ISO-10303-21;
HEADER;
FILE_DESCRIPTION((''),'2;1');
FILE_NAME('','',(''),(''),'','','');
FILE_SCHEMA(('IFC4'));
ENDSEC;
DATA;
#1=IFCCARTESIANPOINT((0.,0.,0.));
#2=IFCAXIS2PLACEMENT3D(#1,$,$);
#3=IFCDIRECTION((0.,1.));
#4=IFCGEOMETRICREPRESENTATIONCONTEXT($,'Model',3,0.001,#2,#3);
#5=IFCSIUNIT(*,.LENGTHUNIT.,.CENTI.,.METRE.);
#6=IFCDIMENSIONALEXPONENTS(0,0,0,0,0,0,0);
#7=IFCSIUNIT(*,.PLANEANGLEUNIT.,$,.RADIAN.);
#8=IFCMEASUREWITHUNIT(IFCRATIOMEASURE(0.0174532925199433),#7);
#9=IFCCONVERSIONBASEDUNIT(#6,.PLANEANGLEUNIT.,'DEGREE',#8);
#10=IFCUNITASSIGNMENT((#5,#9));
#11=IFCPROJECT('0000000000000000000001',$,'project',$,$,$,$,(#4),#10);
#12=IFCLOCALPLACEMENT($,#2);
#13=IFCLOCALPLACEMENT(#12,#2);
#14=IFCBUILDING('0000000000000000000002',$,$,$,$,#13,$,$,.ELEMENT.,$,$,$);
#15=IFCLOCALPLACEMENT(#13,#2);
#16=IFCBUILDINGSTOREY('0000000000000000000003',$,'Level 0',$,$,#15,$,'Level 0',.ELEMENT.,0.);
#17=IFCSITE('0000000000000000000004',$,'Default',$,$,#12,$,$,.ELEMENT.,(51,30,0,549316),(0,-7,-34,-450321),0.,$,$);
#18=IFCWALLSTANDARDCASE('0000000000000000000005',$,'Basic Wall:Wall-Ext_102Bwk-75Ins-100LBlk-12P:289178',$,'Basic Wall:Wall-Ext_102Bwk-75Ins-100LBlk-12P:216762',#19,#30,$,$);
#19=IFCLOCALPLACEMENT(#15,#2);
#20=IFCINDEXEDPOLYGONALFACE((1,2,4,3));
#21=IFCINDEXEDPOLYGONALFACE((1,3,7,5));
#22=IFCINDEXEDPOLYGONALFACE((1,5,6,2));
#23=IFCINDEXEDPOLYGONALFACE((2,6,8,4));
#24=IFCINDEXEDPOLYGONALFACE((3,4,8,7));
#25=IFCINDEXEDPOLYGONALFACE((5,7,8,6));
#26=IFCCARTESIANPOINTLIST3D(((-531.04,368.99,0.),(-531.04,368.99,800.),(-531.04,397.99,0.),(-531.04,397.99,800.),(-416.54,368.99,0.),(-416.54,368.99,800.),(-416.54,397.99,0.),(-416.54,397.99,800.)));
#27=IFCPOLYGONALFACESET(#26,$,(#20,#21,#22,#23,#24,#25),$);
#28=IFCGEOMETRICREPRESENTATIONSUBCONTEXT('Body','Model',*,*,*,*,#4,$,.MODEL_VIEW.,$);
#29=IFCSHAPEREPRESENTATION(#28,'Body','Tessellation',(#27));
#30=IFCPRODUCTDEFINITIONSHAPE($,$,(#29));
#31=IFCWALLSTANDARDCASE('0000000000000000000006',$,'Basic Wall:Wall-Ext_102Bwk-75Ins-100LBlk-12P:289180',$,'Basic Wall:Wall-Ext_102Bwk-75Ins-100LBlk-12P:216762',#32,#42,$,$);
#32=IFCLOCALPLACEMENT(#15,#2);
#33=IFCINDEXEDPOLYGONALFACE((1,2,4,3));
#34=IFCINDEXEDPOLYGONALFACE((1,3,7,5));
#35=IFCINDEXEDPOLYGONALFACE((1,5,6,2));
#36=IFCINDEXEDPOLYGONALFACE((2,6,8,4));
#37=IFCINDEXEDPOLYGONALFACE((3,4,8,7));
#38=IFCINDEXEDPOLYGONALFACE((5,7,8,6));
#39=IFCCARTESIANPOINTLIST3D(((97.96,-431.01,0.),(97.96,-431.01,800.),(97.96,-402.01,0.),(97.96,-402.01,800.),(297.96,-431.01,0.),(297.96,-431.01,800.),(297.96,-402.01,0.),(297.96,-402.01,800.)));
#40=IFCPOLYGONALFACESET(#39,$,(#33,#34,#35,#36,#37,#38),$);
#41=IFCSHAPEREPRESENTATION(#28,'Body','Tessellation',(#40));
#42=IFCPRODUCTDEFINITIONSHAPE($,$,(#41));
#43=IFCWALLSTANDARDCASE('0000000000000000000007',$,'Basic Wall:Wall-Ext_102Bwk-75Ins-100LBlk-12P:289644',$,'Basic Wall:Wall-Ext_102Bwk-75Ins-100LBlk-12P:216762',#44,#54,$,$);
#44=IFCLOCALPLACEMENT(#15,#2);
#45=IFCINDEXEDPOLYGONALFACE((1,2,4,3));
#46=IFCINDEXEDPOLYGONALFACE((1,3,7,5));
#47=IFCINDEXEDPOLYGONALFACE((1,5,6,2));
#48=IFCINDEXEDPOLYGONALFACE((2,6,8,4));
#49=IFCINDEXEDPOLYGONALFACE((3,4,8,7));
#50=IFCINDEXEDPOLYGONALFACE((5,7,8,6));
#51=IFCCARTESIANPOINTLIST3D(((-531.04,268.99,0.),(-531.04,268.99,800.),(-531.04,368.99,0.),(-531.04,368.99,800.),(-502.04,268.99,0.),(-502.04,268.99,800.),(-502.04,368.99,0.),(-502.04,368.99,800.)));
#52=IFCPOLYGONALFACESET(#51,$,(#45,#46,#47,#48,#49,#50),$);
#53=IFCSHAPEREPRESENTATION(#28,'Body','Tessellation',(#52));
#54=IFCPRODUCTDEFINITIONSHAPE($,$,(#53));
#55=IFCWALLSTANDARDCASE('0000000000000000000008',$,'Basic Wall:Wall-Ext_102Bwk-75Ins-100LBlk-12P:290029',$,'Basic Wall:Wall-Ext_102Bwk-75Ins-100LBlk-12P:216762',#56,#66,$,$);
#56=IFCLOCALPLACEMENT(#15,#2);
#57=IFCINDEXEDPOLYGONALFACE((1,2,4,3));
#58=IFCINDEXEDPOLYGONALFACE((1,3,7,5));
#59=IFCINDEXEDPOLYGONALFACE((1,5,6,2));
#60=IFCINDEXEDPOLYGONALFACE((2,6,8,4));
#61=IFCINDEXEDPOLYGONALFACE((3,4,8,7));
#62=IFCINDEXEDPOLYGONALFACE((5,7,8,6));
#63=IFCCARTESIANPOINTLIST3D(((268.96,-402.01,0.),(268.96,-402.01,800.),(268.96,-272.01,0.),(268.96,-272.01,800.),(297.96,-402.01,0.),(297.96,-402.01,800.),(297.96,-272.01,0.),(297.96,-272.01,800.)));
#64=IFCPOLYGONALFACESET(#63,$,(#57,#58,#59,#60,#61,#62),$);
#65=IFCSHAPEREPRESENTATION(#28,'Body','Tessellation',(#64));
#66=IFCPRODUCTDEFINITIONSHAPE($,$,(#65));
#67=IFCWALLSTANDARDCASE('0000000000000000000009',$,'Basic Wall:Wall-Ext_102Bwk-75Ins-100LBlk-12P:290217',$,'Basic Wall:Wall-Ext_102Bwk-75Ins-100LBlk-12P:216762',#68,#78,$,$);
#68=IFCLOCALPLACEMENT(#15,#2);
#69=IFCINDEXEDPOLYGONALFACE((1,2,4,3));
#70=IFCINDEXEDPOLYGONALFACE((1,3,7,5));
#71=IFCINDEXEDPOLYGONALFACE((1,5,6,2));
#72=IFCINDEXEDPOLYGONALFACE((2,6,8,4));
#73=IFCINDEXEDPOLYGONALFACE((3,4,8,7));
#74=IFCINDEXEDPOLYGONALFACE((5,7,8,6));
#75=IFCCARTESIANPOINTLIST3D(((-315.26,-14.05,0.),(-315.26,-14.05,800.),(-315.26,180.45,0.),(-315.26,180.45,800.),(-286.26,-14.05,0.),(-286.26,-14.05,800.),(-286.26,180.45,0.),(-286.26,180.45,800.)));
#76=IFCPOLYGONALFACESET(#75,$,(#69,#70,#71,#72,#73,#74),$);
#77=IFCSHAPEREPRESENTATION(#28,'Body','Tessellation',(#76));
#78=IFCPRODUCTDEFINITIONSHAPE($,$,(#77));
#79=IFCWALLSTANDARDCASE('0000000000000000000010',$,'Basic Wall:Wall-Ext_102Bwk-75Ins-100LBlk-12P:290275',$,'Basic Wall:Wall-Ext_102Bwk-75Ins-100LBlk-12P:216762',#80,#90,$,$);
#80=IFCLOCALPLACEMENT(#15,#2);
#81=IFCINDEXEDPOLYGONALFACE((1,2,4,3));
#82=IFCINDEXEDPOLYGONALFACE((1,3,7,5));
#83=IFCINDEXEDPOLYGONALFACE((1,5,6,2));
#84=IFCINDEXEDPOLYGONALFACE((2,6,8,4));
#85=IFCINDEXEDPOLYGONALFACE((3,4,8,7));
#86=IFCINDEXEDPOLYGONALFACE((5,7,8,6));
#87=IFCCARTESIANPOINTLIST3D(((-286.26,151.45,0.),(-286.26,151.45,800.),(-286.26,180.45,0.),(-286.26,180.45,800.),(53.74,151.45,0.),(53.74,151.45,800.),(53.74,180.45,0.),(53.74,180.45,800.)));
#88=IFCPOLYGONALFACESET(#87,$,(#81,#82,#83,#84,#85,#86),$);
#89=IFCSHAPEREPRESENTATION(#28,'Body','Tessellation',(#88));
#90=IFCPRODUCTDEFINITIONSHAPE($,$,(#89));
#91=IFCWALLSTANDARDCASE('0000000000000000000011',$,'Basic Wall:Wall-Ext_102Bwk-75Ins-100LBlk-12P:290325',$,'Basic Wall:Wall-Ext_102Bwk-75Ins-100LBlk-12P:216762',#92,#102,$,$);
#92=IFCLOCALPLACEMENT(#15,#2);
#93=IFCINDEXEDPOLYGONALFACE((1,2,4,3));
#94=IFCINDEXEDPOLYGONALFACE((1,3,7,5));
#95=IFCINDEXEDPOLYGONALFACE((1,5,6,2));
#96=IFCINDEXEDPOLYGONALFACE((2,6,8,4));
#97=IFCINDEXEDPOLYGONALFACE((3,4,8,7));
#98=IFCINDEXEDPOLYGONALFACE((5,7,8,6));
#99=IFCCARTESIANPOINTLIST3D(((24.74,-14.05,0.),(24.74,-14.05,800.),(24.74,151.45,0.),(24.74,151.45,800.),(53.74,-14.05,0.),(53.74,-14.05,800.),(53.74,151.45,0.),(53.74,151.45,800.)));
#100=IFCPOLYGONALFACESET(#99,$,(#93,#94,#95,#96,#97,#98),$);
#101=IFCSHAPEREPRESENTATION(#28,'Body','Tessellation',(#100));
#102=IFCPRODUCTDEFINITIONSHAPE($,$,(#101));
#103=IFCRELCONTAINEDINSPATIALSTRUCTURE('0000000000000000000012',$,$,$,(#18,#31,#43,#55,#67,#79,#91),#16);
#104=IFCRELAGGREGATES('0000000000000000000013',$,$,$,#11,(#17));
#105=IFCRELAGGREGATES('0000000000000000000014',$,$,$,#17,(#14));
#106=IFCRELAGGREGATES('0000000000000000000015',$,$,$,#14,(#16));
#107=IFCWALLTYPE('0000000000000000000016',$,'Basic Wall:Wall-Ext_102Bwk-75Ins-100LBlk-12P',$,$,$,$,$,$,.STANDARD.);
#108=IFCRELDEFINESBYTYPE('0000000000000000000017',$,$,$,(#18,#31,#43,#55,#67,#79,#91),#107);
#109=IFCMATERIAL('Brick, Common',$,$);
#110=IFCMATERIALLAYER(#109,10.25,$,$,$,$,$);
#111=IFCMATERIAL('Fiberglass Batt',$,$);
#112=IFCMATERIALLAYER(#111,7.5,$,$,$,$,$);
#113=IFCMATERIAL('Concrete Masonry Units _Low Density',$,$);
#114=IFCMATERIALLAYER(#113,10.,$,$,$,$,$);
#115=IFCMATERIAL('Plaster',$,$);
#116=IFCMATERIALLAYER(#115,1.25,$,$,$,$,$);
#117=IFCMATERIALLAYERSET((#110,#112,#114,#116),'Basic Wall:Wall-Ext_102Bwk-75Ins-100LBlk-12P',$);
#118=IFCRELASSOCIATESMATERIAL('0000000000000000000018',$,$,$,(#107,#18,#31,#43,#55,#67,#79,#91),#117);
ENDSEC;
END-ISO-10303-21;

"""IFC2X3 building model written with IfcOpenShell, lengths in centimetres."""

from ifc_helpers import new_model, entity, si_unit, converted_unit, direction, frame, frame_2d, origin, place, context, subcontext, project, spatial, rectangle, extrude, material, layer, layer_set, layer_usage, type_object, element, save


model = new_model("IFC2X3")

# Units and contexts
model_context = context("Model", 3, precision=0.001, world=origin(), true_north=direction((0.0, 1.0)))
body_context = subcontext(model_context, "Body", "Model", "MODEL_VIEW")
ifc_project = project(units=[si_unit("LENGTHUNIT", "METRE", prefix="CENTI"), converted_unit("PLANEANGLEUNIT", "DEGREE", entity("IfcRatioMeasure", 0.0174532925199433), si_unit("PLANEANGLEUNIT", "RADIAN"), dimensions=[0, 0, 0, 0, 0, 0, 0])], contexts=[model_context])

# Site, building, storey
site_placement = place(None, origin())
site = spatial("IfcSite", under=ifc_project, at=site_placement, Name="Default", CompositionType="ELEMENT", RefLatitude=(51, 30, 0, 549316), RefLongitude=(0, -7, -34, -450321), RefElevation=0.0)
building_placement = place(site_placement, origin())
building = spatial("IfcBuilding", under=site, at=building_placement, CompositionType="ELEMENT")
storey_placement = place(building_placement, origin())
storey = spatial("IfcBuildingStorey", under=building, at=storey_placement, Name="Level 0", LongName="Level 0", CompositionType="ELEMENT", Elevation=0.0)

# Walls
ifc_material_1 = material(Name="Brick, Common")
ifc_layer_1 = layer(ifc_material_1, 10.25)
ifc_material_2 = material(Name="Fiberglass Batt")
ifc_layer_2 = layer(ifc_material_2, 7.5)
ifc_material_3 = material(Name="Concrete Masonry Units _Low Density")
ifc_layer_3 = layer(ifc_material_3, 10.0)
ifc_material_4 = material(Name="Plaster")
ifc_layer_4 = layer(ifc_material_4, 1.25)
ifc_layer_set = layer_set([ifc_layer_1, ifc_layer_2, ifc_layer_3, ifc_layer_4], Name="Basic Wall:Wall-Ext_102Bwk-75Ins-100LBlk-12P")
ifc_layer_usage_1 = layer_usage(ifc_layer_set, "AXIS2", "NEGATIVE", 14.5)
wall_type = type_object("IfcWallType", Name="Basic Wall:Wall-Ext_102Bwk-75Ins-100LBlk-12P", PredefinedType="STANDARD", material=ifc_layer_set)
wall_1_placement = place(storey_placement, frame((-531.04, 383.49, 0.0)))
element("IfcWallStandardCase", 1, at=wall_1_placement, inside=storey, type_object=wall_type, material=ifc_layer_usage_1, Name="Basic Wall:Wall-Ext_102Bwk-75Ins-100LBlk-12P:289178", ObjectType="Basic Wall:Wall-Ext_102Bwk-75Ins-100LBlk-12P:216762", context=body_context, shape_type="SweptSolid", body=[
    extrude(rectangle(XDim=114.5, YDim=29.0, at=frame_2d((57.25, 0.0), x_axis=(-1.0, 0.0))), origin(), (0.0, 0.0, 1.0), 800.0),
])
ifc_layer_usage_2 = layer_usage(ifc_layer_set, "AXIS2", "NEGATIVE", 14.5)
wall_2_placement = place(storey_placement, frame((297.96, -416.51, 0.0), z_axis=(0.0, 0.0, 1.0), x_axis=(-1.0, 0.0, 0.0)))
element("IfcWallStandardCase", 2, at=wall_2_placement, inside=storey, type_object=wall_type, material=ifc_layer_usage_2, Name="Basic Wall:Wall-Ext_102Bwk-75Ins-100LBlk-12P:289180", ObjectType="Basic Wall:Wall-Ext_102Bwk-75Ins-100LBlk-12P:216762", context=body_context, shape_type="SweptSolid", body=[
    extrude(rectangle(XDim=200.0, YDim=29.0, at=frame_2d((100.0, 0.0), x_axis=(-1.0, 0.0))), origin(), (0.0, 0.0, 1.0), 800.0),
])
ifc_layer_usage_3 = layer_usage(ifc_layer_set, "AXIS2", "NEGATIVE", 14.5)
wall_3_placement = place(storey_placement, frame((-516.54, 268.99, 0.0), z_axis=(0.0, 0.0, 1.0), x_axis=(0.0, 1.0, 0.0)))
element("IfcWallStandardCase", 3, at=wall_3_placement, inside=storey, type_object=wall_type, material=ifc_layer_usage_3, Name="Basic Wall:Wall-Ext_102Bwk-75Ins-100LBlk-12P:289644", ObjectType="Basic Wall:Wall-Ext_102Bwk-75Ins-100LBlk-12P:216762", context=body_context, shape_type="SweptSolid", body=[
    extrude(rectangle(XDim=100.0, YDim=29.0, at=frame_2d((50.0, 0.0), x_axis=(-1.0, 0.0))), origin(), (0.0, 0.0, 1.0), 800.0),
])
ifc_layer_usage_4 = layer_usage(ifc_layer_set, "AXIS2", "NEGATIVE", 14.5)
wall_4_placement = place(storey_placement, frame((283.46, -272.01, 0.0), z_axis=(0.0, 0.0, 1.0), x_axis=(0.0, -1.0, 0.0)))
element("IfcWallStandardCase", 4, at=wall_4_placement, inside=storey, type_object=wall_type, material=ifc_layer_usage_4, Name="Basic Wall:Wall-Ext_102Bwk-75Ins-100LBlk-12P:290029", ObjectType="Basic Wall:Wall-Ext_102Bwk-75Ins-100LBlk-12P:216762", context=body_context, shape_type="SweptSolid", body=[
    extrude(rectangle(XDim=130.0, YDim=29.0, at=frame_2d((65.0, 0.0), x_axis=(-1.0, 0.0))), origin(), (0.0, 0.0, 1.0), 800.0),
])
ifc_layer_usage_5 = layer_usage(ifc_layer_set, "AXIS2", "NEGATIVE", 14.5)
wall_5_placement = place(storey_placement, frame((-300.76, -14.05, 0.0), z_axis=(0.0, 0.0, 1.0), x_axis=(0.0, 1.0, 0.0)))
element("IfcWallStandardCase", 5, at=wall_5_placement, inside=storey, type_object=wall_type, material=ifc_layer_usage_5, Name="Basic Wall:Wall-Ext_102Bwk-75Ins-100LBlk-12P:290217", ObjectType="Basic Wall:Wall-Ext_102Bwk-75Ins-100LBlk-12P:216762", context=body_context, shape_type="SweptSolid", body=[
    extrude(rectangle(XDim=194.5, YDim=29.0, at=frame_2d((97.25, 0.0), x_axis=(-1.0, 0.0))), origin(), (0.0, 0.0, 1.0), 800.0),
])
ifc_layer_usage_6 = layer_usage(ifc_layer_set, "AXIS2", "NEGATIVE", 14.5)
wall_6_placement = place(storey_placement, frame((-286.26, 165.95, 0.0)))
element("IfcWallStandardCase", 6, at=wall_6_placement, inside=storey, type_object=wall_type, material=ifc_layer_usage_6, Name="Basic Wall:Wall-Ext_102Bwk-75Ins-100LBlk-12P:290275", ObjectType="Basic Wall:Wall-Ext_102Bwk-75Ins-100LBlk-12P:216762", context=body_context, shape_type="SweptSolid", body=[
    extrude(rectangle(XDim=340.0, YDim=29.0, at=frame_2d((170.0, 0.0), x_axis=(-1.0, 0.0))), origin(), (0.0, 0.0, 1.0), 800.0),
])
ifc_layer_usage_7 = layer_usage(ifc_layer_set, "AXIS2", "NEGATIVE", 14.5)
wall_7_placement = place(storey_placement, frame((39.24, 151.45, 0.0), z_axis=(0.0, 0.0, 1.0), x_axis=(0.0, -1.0, 0.0)))
element("IfcWallStandardCase", 7, at=wall_7_placement, inside=storey, type_object=wall_type, material=ifc_layer_usage_7, Name="Basic Wall:Wall-Ext_102Bwk-75Ins-100LBlk-12P:290325", ObjectType="Basic Wall:Wall-Ext_102Bwk-75Ins-100LBlk-12P:216762", context=body_context, shape_type="SweptSolid", body=[
    extrude(rectangle(XDim=165.5, YDim=29.0, at=frame_2d((82.75, 0.0), x_axis=(-1.0, 0.0))), origin(), (0.0, 0.0, 1.0), 800.0),
])

save(model, "model.ifc")
